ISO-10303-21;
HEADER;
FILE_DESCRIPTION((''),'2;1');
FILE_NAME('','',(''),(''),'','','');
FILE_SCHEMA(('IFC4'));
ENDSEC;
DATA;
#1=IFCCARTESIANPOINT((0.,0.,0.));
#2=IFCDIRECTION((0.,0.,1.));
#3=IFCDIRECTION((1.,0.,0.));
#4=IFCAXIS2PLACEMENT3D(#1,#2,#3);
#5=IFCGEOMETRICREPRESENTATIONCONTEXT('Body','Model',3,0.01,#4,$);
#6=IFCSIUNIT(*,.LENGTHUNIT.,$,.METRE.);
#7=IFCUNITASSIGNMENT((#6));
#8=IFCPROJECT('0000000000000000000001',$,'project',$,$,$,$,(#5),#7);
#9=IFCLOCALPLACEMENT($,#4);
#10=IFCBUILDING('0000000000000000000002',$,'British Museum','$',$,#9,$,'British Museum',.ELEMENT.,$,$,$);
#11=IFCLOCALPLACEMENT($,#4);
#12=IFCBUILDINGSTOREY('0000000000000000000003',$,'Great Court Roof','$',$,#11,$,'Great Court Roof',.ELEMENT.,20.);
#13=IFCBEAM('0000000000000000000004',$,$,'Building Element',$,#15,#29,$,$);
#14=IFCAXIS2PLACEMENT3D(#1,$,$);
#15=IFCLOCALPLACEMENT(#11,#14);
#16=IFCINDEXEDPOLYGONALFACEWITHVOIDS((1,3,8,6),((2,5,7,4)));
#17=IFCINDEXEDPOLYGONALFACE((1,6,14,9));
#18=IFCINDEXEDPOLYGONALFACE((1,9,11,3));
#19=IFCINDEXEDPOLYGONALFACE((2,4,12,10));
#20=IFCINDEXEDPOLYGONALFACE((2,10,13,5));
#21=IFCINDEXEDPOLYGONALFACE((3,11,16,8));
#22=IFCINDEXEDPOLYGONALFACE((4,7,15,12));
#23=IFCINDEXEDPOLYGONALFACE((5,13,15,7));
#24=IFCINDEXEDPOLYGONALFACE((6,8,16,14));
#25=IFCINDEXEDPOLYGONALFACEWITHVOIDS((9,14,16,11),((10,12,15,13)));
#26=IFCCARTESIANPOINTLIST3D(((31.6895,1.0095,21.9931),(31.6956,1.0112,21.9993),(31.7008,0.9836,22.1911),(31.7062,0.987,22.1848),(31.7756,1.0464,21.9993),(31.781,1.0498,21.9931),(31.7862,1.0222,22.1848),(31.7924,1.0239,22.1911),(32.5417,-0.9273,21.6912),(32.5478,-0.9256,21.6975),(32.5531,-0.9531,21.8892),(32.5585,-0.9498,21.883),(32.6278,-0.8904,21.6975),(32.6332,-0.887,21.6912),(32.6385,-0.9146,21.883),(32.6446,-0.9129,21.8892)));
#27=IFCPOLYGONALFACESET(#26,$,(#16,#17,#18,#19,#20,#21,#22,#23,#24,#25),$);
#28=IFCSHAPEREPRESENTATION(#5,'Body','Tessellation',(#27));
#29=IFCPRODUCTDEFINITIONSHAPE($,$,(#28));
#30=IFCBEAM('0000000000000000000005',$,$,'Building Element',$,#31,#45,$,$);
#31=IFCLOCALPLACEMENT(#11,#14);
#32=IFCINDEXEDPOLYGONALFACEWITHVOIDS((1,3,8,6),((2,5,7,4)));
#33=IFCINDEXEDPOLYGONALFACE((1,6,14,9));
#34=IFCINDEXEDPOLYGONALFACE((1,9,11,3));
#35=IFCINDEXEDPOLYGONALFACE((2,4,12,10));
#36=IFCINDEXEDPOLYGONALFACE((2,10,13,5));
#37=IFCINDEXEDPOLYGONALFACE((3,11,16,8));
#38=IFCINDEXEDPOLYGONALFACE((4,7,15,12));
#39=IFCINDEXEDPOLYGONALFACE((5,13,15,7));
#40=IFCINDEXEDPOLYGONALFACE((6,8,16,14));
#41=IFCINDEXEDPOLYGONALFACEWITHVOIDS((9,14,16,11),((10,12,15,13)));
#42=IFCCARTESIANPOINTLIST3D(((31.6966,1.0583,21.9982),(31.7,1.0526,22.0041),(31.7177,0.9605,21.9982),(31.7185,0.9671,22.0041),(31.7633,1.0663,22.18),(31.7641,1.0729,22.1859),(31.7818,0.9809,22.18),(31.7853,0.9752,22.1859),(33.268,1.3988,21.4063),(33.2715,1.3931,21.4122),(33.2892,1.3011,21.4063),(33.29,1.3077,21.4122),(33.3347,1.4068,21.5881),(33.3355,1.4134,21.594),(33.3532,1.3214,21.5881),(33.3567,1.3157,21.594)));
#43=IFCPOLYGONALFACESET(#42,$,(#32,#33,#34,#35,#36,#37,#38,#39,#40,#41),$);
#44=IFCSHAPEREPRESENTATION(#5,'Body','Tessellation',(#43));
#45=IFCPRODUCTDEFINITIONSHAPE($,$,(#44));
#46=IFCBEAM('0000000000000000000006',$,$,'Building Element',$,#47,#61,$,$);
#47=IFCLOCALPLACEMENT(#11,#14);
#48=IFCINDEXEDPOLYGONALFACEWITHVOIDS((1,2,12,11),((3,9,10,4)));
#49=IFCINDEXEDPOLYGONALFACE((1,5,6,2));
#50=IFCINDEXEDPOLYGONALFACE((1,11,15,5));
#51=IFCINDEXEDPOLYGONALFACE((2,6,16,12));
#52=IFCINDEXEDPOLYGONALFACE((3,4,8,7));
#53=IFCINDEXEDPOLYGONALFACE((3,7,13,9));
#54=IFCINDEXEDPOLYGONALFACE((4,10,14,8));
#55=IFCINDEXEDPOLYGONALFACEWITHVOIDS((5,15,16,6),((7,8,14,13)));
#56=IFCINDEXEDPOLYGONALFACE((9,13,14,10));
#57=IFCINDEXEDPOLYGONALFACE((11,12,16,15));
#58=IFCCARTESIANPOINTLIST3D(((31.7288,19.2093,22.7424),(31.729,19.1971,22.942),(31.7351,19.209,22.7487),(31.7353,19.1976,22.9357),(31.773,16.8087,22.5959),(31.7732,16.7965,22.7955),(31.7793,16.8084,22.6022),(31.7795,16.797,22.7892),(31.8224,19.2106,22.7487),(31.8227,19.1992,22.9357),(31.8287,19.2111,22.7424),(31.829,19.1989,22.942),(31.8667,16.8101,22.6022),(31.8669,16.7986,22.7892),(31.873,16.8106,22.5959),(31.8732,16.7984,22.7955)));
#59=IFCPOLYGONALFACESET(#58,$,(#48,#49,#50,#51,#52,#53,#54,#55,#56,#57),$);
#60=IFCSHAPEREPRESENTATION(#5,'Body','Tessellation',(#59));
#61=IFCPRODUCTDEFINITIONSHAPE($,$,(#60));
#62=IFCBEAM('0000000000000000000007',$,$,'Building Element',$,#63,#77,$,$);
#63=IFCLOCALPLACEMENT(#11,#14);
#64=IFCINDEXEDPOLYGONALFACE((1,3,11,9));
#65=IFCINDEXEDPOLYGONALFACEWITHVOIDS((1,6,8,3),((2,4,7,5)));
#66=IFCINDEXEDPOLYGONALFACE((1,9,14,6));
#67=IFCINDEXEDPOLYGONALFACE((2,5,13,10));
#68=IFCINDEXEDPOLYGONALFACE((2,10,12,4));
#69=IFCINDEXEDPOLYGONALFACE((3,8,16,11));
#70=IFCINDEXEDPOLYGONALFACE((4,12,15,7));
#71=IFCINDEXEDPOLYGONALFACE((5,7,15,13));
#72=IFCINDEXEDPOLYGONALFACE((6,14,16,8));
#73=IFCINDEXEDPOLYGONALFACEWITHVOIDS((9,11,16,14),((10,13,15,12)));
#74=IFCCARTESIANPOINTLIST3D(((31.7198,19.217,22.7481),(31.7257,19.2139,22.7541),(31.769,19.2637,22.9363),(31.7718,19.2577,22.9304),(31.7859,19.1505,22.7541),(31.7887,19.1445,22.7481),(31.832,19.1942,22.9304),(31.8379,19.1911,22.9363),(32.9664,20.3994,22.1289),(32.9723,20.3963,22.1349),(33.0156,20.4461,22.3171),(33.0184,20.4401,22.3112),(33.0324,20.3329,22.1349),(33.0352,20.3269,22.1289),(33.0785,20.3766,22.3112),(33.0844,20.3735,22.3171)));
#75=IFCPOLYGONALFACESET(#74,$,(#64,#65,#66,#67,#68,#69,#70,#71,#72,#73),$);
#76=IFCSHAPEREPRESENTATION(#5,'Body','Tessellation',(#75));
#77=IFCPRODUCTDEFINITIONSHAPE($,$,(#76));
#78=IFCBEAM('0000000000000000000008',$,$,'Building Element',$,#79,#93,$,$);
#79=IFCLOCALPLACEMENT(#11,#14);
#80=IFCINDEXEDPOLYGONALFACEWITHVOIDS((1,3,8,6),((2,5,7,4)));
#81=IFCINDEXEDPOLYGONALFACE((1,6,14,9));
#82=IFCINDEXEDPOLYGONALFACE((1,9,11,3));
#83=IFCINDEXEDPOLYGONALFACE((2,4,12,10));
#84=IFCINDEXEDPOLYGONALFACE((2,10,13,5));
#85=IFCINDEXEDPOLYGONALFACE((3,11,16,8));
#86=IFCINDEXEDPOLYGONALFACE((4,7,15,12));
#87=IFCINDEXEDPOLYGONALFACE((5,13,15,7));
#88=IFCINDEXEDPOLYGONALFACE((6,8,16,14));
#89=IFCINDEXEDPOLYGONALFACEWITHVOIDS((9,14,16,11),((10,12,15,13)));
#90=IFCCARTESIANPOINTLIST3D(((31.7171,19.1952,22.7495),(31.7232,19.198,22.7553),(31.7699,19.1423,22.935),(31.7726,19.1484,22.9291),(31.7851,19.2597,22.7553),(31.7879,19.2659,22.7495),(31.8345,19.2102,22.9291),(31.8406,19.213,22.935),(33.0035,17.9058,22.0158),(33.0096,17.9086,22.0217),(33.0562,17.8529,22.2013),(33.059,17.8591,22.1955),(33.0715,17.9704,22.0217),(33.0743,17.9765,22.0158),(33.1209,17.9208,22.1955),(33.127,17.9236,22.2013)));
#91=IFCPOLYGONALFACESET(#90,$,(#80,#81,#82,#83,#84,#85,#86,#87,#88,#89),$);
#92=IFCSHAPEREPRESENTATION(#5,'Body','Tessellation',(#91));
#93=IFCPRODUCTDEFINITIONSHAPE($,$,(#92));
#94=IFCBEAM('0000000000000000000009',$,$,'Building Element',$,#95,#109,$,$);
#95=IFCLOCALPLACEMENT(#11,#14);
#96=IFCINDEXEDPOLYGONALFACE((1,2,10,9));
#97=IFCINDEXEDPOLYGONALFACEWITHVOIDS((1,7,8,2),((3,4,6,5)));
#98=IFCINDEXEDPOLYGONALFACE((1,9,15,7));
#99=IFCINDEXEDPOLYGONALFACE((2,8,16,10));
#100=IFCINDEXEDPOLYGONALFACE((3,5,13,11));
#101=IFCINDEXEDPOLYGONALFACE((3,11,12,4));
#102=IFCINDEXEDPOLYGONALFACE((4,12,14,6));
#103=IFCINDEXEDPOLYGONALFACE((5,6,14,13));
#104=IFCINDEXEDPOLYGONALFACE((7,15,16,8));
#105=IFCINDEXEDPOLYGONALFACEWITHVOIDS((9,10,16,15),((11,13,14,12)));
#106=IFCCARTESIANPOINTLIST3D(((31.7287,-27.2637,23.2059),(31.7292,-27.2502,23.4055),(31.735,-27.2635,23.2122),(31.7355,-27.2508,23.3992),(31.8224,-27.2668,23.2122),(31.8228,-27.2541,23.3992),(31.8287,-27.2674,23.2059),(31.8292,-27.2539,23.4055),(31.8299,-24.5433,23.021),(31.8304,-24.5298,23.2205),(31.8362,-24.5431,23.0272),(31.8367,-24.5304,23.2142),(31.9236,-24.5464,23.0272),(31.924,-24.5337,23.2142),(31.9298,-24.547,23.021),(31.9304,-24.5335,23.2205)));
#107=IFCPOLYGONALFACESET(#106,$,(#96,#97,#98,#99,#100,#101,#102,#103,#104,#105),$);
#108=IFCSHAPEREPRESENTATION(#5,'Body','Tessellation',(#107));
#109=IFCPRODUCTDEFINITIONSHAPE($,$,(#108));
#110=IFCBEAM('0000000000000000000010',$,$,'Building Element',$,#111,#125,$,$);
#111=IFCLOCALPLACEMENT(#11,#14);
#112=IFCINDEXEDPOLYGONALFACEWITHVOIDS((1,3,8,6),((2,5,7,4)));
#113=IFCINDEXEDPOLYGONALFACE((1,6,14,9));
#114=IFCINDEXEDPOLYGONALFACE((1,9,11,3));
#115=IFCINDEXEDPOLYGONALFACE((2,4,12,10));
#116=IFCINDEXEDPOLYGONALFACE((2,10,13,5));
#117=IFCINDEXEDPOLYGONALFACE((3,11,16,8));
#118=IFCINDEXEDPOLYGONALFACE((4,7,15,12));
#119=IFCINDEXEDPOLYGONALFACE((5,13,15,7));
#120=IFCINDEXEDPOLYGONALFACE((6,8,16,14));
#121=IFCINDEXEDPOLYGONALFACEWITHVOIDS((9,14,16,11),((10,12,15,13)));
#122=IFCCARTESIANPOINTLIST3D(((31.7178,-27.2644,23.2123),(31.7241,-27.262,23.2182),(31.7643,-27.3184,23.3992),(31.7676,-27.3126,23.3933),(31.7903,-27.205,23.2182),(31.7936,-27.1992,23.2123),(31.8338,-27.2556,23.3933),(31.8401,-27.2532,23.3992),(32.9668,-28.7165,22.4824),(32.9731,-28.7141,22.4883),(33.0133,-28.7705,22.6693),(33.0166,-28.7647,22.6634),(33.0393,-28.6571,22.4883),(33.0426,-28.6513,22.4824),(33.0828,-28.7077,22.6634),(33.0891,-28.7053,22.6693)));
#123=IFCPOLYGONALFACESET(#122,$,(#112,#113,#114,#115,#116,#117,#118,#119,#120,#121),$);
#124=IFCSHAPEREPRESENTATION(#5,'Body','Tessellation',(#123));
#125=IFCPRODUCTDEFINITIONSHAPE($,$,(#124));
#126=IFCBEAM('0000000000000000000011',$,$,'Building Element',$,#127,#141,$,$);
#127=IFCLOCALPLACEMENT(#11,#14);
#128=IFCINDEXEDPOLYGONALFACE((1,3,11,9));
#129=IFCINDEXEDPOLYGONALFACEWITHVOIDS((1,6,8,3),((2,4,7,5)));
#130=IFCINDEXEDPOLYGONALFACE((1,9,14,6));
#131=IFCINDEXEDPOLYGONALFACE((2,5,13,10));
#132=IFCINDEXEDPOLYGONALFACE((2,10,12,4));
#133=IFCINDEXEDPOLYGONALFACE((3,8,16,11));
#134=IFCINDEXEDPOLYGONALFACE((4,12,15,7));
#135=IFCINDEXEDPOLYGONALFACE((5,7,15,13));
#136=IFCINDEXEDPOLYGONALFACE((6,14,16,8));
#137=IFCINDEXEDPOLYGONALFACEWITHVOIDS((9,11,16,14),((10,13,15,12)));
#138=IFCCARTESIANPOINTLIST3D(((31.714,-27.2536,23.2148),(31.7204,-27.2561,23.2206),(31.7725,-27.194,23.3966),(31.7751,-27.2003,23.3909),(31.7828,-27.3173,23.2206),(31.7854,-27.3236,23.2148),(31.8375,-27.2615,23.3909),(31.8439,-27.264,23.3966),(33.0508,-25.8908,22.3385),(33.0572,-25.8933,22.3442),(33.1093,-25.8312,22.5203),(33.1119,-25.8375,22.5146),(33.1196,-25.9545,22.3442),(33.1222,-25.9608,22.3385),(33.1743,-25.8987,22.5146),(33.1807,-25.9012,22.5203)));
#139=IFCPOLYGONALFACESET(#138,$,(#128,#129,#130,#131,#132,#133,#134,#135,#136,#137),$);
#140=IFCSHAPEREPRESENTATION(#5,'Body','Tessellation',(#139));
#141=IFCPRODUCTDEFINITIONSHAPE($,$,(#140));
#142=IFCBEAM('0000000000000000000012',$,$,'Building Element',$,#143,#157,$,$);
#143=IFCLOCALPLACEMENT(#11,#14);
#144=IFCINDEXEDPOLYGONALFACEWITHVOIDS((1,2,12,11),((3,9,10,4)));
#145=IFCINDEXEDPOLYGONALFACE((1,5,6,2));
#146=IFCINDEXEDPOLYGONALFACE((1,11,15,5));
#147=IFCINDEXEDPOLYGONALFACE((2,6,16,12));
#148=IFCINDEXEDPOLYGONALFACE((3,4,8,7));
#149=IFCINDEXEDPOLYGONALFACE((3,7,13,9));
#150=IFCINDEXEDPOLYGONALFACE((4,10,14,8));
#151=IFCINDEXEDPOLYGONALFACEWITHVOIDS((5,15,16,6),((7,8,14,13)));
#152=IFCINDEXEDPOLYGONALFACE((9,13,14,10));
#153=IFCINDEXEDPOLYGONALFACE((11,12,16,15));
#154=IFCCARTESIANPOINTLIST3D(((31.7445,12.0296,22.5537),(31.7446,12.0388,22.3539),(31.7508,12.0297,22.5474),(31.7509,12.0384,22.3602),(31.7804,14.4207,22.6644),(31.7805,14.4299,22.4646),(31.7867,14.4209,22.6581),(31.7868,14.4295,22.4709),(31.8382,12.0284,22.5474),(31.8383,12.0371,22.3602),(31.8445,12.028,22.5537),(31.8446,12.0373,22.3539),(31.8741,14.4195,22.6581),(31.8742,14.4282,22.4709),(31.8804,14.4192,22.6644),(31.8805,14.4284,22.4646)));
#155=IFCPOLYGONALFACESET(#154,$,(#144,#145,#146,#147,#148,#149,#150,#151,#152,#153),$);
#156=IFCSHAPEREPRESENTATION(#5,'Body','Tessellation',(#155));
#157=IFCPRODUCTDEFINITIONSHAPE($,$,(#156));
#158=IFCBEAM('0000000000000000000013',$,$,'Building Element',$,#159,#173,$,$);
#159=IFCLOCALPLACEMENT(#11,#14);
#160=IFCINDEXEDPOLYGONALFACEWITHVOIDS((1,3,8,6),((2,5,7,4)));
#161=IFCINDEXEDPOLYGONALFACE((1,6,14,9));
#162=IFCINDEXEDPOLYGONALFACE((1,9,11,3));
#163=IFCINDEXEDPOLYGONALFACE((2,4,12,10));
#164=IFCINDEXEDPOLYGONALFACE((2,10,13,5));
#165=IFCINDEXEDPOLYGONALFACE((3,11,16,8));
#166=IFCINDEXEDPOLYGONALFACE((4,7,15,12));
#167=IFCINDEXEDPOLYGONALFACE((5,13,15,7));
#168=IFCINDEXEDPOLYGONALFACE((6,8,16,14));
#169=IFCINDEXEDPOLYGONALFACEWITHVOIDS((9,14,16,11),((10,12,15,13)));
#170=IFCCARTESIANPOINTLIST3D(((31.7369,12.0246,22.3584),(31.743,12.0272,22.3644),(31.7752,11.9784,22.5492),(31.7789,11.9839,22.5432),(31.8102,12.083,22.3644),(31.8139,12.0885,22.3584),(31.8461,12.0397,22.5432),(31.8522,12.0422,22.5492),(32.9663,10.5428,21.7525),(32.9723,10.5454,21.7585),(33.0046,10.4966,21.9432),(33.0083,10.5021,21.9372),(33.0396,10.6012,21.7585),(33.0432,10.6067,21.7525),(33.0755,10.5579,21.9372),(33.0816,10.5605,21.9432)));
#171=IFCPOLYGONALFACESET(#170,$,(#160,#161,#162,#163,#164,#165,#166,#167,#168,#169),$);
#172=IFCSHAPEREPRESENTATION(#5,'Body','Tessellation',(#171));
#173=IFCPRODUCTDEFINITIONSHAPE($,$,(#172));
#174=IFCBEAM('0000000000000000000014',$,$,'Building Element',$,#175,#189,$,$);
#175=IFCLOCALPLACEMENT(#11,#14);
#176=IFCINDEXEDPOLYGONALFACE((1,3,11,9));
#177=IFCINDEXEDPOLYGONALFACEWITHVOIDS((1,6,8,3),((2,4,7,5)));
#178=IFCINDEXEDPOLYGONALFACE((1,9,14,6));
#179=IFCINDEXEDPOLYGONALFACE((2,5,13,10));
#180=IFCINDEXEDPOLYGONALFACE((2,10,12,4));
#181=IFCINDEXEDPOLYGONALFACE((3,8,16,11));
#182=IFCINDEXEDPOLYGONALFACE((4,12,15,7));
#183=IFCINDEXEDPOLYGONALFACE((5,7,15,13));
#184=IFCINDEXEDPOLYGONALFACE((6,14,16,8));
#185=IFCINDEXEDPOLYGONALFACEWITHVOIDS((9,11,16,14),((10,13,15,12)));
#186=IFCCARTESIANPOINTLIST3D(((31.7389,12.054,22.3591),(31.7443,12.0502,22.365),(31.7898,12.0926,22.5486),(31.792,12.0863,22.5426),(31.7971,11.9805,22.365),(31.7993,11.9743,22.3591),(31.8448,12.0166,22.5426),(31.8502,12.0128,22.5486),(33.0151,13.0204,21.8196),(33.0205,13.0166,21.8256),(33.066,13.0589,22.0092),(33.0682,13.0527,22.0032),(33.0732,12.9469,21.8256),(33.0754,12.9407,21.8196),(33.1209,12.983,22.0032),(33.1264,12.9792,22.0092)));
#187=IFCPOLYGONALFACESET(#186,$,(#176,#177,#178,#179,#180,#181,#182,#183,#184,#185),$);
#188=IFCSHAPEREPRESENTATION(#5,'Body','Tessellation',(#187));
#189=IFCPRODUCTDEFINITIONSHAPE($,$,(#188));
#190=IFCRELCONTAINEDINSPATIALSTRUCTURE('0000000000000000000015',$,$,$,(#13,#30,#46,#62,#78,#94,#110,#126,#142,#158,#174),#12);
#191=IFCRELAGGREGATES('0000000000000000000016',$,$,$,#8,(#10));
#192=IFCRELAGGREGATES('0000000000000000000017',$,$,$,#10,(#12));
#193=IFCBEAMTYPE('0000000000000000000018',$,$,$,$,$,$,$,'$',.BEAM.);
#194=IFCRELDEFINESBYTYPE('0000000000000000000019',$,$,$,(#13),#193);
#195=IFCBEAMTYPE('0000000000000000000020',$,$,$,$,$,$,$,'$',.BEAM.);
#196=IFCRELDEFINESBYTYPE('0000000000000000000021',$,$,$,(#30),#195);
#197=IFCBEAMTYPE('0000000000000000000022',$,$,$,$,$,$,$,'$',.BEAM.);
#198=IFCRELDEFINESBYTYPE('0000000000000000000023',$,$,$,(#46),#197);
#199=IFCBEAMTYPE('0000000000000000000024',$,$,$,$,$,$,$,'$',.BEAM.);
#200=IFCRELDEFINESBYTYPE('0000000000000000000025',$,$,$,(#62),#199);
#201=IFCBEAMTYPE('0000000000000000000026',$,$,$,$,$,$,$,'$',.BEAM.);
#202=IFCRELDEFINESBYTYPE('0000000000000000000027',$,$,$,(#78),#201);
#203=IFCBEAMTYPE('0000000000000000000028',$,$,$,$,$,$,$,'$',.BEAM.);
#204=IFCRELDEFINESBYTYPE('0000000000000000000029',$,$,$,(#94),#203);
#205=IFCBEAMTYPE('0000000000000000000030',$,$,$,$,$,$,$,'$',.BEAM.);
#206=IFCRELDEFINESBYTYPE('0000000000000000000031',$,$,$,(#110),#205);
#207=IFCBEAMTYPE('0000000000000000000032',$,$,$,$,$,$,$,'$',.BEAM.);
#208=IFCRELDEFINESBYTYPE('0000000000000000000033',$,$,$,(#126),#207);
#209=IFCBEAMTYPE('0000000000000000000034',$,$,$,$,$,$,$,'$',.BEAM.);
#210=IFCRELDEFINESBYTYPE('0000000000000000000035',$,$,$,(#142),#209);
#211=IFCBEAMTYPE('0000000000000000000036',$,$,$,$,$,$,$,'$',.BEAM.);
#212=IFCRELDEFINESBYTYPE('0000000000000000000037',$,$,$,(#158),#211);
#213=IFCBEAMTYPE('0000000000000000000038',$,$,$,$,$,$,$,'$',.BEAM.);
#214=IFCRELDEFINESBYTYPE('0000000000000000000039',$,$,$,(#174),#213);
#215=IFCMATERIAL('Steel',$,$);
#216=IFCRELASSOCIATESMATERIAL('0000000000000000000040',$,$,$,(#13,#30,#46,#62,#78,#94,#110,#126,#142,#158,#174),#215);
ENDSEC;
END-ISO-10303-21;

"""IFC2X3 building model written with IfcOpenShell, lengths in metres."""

from ifc_helpers import new_model, si_unit, frame, origin_with_axes, origin_2d, place, context, project, spatial, hollow_rectangle, extrude, material, type_object, element, save


model = new_model("IFC2X3")

# Units and contexts
model_context = context("Model", 3, precision=0.01, world=origin_with_axes(), identifier="Body")
ifc_project = project(units=[si_unit("LENGTHUNIT", "METRE")], contexts=[model_context])

# Building, storey
building_placement = place(None, origin_with_axes())
building = spatial("IfcBuilding", under=ifc_project, at=building_placement, Name="British Museum", Description="$", LongName="British Museum", CompositionType="ELEMENT")
storey_placement = place(None, origin_with_axes())
storey = spatial("IfcBuildingStorey", under=building, at=storey_placement, Name="Great Court Roof", Description="$", LongName="Great Court Roof", CompositionType="ELEMENT", Elevation=20.0)

# Beams
ifc_material = material(Name="Steel")
beam_type_1 = type_object("IfcBeamType", ElementType="$", PredefinedType="BEAM")
beam_1_placement = place(None, origin_with_axes())
element("IfcBeam", 1, at=beam_1_placement, inside=storey, type_object=beam_type_1, material=ifc_material, Description="Building Element", context=model_context, shape_type="SweptSolid", body=[
    extrude(hollow_rectangle(XDim=0.1, YDim=0.2, WallThickness=0.0063, InnerFilletRadius=-0.0063, OuterFilletRadius=0.0, at=origin_2d()), frame((31.7409, 1.0167, 22.0921), z_axis=(0.398724, -0.906135, -0.141205), x_axis=(0.915306, 0.402759, 0.0)), (0.0, 0.0, 1.0), 2.1374),
])
beam_type_2 = type_object("IfcBeamType", ElementType="$", PredefinedType="BEAM")
beam_2_placement = place(None, origin_with_axes())
element("IfcBeam", 2, at=beam_2_placement, inside=storey, type_object=beam_type_2, material=ifc_material, Description="Building Element", context=model_context, shape_type="SweptSolid", body=[
    extrude(hollow_rectangle(XDim=0.1, YDim=0.2, WallThickness=0.0063, InnerFilletRadius=-0.0063, OuterFilletRadius=0.0, at=origin_2d()), frame((31.7409, 1.0167, 22.0921), z_axis=(0.917146, 0.198746, -0.34546), x_axis=(-0.211785, 0.977316, 0.0)), (0.0, 0.0, 1.0), 1.7134),
])
beam_type_3 = type_object("IfcBeamType", ElementType="$", PredefinedType="BEAM")
beam_3_placement = place(None, origin_with_axes())
element("IfcBeam", 3, at=beam_3_placement, inside=storey, type_object=beam_type_3, material=ifc_material, Description="Building Element", context=model_context, shape_type="SweptSolid", body=[
    extrude(hollow_rectangle(XDim=0.1, YDim=0.2, WallThickness=0.0063, InnerFilletRadius=-0.0063, OuterFilletRadius=0.0, at=origin_2d()), frame((31.7789, 19.2041, 22.8422), z_axis=(0.018388, -0.997974, -0.060916), x_axis=(0.99983, 0.018423, 0.0)), (0.0, 0.0, 1.0), 2.4054),
])
beam_type_4 = type_object("IfcBeamType", ElementType="$", PredefinedType="BEAM")
beam_4_placement = place(None, origin_with_axes())
element("IfcBeam", 4, at=beam_4_placement, inside=storey, type_object=beam_type_4, material=ifc_material, Description="Building Element", context=model_context, shape_type="SweptSolid", body=[
    extrude(hollow_rectangle(XDim=0.1, YDim=0.2, WallThickness=0.0063, InnerFilletRadius=-0.0063, OuterFilletRadius=0.0, at=origin_2d()), frame((31.7789, 19.2041, 22.8422), z_axis=(0.682549, 0.647436, -0.339048), x_axis=(-0.688199, 0.725522, 0.0)), (0.0, 0.0, 1.0), 1.8263),
])
beam_type_5 = type_object("IfcBeamType", ElementType="$", PredefinedType="BEAM")
beam_5_placement = place(None, origin_with_axes())
element("IfcBeam", 5, at=beam_5_placement, inside=storey, type_object=beam_type_5, material=ifc_material, Description="Building Element", context=model_context, shape_type="SweptSolid", body=[
    extrude(hollow_rectangle(XDim=0.1, YDim=0.2, WallThickness=0.0063, InnerFilletRadius=-0.0063, OuterFilletRadius=0.0, at=origin_2d()), frame((31.7789, 19.2041, 22.8422), z_axis=(0.655135, -0.656658, -0.373628), x_axis=(0.707927, 0.706285, 0.0)), (0.0, 0.0, 1.0), 1.9636),
])
beam_type_6 = type_object("IfcBeamType", ElementType="$", PredefinedType="BEAM")
beam_6_placement = place(None, origin_with_axes())
element("IfcBeam", 6, at=beam_6_placement, inside=storey, type_object=beam_type_6, material=ifc_material, Description="Building Element", context=model_context, shape_type="SweptSolid", body=[
    extrude(hollow_rectangle(XDim=0.1, YDim=0.2, WallThickness=0.0063, InnerFilletRadius=-0.0063, OuterFilletRadius=0.0, at=origin_2d()), frame((31.7789, -27.2588, 23.3057), z_axis=(0.037087, 0.99701, -0.067796), x_axis=(-0.999309, 0.037172, 0.0)), (0.0, 0.0, 1.0), 2.7286),
])
beam_type_7 = type_object("IfcBeamType", ElementType="$", PredefinedType="BEAM")
beam_7_placement = place(None, origin_with_axes())
element("IfcBeam", 7, at=beam_7_placement, inside=storey, type_object=beam_type_7, material=ifc_material, Description="Building Element", context=model_context, shape_type="SweptSolid", body=[
    extrude(hollow_rectangle(XDim=0.1, YDim=0.2, WallThickness=0.0063, InnerFilletRadius=-0.0063, OuterFilletRadius=0.0, at=origin_2d()), frame((31.7789, -27.2588, 23.3057), z_axis=(0.609367, -0.708437, -0.356074), x_axis=(0.758126, 0.652108, 0.0)), (0.0, 0.0, 1.0), 2.0497),
])
beam_type_8 = type_object("IfcBeamType", ElementType="$", PredefinedType="BEAM")
beam_8_placement = place(None, origin_with_axes())
element("IfcBeam", 8, at=beam_8_placement, inside=storey, type_object=beam_type_8, material=ifc_material, Description="Building Element", context=model_context, shape_type="SweptSolid", body=[
    extrude(hollow_rectangle(XDim=0.1, YDim=0.2, WallThickness=0.0063, InnerFilletRadius=-0.0063, OuterFilletRadius=0.0, at=origin_2d()), frame((31.7789, -27.2588, 23.3057), z_axis=(0.636414, 0.648793, -0.417187), x_axis=(-0.713885, 0.700263, 0.0)), (0.0, 0.0, 1.0), 2.1005),
])
beam_type_9 = type_object("IfcBeamType", ElementType="$", PredefinedType="BEAM")
beam_9_placement = place(None, origin_with_axes())
element("IfcBeam", 9, at=beam_9_placement, inside=storey, type_object=beam_type_9, material=ifc_material, Description="Building Element", context=model_context, shape_type="SweptSolid", body=[
    extrude(hollow_rectangle(XDim=0.1, YDim=0.2, WallThickness=0.0063, InnerFilletRadius=-0.0063, OuterFilletRadius=0.0, at=origin_2d()), frame((31.7946, 12.0334, 22.4538), z_axis=(0.015002, 0.998818, 0.046237), x_axis=(-0.999887, 0.015019, 0.0)), (0.0, 0.0, 1.0), 2.3939),
])
beam_type_10 = type_object("IfcBeamType", ElementType="$", PredefinedType="BEAM")
beam_10_placement = place(None, origin_with_axes())
element("IfcBeam", 10, at=beam_10_placement, inside=storey, type_object=beam_type_10, material=ifc_material, Description="Building Element", context=model_context, shape_type="SweptSolid", body=[
    extrude(hollow_rectangle(XDim=0.1, YDim=0.2, WallThickness=0.0063, InnerFilletRadius=-0.0063, OuterFilletRadius=0.0, at=origin_2d()), frame((31.7946, 12.0334, 22.4538), z_axis=(0.609056, -0.734113, -0.300215), x_axis=(0.769614, 0.638509, 0.0)), (0.0, 0.0, 1.0), 2.0185),
])
beam_type_11 = type_object("IfcBeamType", ElementType="$", PredefinedType="BEAM")
beam_11_placement = place(None, origin_with_axes())
element("IfcBeam", 11, at=beam_11_placement, inside=storey, type_object=beam_type_11, material=ifc_material, Description="Building Element", context=model_context, shape_type="SweptSolid", body=[
    extrude(hollow_rectangle(XDim=0.1, YDim=0.2, WallThickness=0.0063, InnerFilletRadius=-0.0063, OuterFilletRadius=0.0, at=origin_2d()), frame((31.7946, 12.0334, 22.4538), z_axis=(0.755475, 0.572084, -0.31934), x_axis=(-0.603693, 0.797217, 0.0)), (0.0, 0.0, 1.0), 1.6892),
])

save(model, "model.ifc")
